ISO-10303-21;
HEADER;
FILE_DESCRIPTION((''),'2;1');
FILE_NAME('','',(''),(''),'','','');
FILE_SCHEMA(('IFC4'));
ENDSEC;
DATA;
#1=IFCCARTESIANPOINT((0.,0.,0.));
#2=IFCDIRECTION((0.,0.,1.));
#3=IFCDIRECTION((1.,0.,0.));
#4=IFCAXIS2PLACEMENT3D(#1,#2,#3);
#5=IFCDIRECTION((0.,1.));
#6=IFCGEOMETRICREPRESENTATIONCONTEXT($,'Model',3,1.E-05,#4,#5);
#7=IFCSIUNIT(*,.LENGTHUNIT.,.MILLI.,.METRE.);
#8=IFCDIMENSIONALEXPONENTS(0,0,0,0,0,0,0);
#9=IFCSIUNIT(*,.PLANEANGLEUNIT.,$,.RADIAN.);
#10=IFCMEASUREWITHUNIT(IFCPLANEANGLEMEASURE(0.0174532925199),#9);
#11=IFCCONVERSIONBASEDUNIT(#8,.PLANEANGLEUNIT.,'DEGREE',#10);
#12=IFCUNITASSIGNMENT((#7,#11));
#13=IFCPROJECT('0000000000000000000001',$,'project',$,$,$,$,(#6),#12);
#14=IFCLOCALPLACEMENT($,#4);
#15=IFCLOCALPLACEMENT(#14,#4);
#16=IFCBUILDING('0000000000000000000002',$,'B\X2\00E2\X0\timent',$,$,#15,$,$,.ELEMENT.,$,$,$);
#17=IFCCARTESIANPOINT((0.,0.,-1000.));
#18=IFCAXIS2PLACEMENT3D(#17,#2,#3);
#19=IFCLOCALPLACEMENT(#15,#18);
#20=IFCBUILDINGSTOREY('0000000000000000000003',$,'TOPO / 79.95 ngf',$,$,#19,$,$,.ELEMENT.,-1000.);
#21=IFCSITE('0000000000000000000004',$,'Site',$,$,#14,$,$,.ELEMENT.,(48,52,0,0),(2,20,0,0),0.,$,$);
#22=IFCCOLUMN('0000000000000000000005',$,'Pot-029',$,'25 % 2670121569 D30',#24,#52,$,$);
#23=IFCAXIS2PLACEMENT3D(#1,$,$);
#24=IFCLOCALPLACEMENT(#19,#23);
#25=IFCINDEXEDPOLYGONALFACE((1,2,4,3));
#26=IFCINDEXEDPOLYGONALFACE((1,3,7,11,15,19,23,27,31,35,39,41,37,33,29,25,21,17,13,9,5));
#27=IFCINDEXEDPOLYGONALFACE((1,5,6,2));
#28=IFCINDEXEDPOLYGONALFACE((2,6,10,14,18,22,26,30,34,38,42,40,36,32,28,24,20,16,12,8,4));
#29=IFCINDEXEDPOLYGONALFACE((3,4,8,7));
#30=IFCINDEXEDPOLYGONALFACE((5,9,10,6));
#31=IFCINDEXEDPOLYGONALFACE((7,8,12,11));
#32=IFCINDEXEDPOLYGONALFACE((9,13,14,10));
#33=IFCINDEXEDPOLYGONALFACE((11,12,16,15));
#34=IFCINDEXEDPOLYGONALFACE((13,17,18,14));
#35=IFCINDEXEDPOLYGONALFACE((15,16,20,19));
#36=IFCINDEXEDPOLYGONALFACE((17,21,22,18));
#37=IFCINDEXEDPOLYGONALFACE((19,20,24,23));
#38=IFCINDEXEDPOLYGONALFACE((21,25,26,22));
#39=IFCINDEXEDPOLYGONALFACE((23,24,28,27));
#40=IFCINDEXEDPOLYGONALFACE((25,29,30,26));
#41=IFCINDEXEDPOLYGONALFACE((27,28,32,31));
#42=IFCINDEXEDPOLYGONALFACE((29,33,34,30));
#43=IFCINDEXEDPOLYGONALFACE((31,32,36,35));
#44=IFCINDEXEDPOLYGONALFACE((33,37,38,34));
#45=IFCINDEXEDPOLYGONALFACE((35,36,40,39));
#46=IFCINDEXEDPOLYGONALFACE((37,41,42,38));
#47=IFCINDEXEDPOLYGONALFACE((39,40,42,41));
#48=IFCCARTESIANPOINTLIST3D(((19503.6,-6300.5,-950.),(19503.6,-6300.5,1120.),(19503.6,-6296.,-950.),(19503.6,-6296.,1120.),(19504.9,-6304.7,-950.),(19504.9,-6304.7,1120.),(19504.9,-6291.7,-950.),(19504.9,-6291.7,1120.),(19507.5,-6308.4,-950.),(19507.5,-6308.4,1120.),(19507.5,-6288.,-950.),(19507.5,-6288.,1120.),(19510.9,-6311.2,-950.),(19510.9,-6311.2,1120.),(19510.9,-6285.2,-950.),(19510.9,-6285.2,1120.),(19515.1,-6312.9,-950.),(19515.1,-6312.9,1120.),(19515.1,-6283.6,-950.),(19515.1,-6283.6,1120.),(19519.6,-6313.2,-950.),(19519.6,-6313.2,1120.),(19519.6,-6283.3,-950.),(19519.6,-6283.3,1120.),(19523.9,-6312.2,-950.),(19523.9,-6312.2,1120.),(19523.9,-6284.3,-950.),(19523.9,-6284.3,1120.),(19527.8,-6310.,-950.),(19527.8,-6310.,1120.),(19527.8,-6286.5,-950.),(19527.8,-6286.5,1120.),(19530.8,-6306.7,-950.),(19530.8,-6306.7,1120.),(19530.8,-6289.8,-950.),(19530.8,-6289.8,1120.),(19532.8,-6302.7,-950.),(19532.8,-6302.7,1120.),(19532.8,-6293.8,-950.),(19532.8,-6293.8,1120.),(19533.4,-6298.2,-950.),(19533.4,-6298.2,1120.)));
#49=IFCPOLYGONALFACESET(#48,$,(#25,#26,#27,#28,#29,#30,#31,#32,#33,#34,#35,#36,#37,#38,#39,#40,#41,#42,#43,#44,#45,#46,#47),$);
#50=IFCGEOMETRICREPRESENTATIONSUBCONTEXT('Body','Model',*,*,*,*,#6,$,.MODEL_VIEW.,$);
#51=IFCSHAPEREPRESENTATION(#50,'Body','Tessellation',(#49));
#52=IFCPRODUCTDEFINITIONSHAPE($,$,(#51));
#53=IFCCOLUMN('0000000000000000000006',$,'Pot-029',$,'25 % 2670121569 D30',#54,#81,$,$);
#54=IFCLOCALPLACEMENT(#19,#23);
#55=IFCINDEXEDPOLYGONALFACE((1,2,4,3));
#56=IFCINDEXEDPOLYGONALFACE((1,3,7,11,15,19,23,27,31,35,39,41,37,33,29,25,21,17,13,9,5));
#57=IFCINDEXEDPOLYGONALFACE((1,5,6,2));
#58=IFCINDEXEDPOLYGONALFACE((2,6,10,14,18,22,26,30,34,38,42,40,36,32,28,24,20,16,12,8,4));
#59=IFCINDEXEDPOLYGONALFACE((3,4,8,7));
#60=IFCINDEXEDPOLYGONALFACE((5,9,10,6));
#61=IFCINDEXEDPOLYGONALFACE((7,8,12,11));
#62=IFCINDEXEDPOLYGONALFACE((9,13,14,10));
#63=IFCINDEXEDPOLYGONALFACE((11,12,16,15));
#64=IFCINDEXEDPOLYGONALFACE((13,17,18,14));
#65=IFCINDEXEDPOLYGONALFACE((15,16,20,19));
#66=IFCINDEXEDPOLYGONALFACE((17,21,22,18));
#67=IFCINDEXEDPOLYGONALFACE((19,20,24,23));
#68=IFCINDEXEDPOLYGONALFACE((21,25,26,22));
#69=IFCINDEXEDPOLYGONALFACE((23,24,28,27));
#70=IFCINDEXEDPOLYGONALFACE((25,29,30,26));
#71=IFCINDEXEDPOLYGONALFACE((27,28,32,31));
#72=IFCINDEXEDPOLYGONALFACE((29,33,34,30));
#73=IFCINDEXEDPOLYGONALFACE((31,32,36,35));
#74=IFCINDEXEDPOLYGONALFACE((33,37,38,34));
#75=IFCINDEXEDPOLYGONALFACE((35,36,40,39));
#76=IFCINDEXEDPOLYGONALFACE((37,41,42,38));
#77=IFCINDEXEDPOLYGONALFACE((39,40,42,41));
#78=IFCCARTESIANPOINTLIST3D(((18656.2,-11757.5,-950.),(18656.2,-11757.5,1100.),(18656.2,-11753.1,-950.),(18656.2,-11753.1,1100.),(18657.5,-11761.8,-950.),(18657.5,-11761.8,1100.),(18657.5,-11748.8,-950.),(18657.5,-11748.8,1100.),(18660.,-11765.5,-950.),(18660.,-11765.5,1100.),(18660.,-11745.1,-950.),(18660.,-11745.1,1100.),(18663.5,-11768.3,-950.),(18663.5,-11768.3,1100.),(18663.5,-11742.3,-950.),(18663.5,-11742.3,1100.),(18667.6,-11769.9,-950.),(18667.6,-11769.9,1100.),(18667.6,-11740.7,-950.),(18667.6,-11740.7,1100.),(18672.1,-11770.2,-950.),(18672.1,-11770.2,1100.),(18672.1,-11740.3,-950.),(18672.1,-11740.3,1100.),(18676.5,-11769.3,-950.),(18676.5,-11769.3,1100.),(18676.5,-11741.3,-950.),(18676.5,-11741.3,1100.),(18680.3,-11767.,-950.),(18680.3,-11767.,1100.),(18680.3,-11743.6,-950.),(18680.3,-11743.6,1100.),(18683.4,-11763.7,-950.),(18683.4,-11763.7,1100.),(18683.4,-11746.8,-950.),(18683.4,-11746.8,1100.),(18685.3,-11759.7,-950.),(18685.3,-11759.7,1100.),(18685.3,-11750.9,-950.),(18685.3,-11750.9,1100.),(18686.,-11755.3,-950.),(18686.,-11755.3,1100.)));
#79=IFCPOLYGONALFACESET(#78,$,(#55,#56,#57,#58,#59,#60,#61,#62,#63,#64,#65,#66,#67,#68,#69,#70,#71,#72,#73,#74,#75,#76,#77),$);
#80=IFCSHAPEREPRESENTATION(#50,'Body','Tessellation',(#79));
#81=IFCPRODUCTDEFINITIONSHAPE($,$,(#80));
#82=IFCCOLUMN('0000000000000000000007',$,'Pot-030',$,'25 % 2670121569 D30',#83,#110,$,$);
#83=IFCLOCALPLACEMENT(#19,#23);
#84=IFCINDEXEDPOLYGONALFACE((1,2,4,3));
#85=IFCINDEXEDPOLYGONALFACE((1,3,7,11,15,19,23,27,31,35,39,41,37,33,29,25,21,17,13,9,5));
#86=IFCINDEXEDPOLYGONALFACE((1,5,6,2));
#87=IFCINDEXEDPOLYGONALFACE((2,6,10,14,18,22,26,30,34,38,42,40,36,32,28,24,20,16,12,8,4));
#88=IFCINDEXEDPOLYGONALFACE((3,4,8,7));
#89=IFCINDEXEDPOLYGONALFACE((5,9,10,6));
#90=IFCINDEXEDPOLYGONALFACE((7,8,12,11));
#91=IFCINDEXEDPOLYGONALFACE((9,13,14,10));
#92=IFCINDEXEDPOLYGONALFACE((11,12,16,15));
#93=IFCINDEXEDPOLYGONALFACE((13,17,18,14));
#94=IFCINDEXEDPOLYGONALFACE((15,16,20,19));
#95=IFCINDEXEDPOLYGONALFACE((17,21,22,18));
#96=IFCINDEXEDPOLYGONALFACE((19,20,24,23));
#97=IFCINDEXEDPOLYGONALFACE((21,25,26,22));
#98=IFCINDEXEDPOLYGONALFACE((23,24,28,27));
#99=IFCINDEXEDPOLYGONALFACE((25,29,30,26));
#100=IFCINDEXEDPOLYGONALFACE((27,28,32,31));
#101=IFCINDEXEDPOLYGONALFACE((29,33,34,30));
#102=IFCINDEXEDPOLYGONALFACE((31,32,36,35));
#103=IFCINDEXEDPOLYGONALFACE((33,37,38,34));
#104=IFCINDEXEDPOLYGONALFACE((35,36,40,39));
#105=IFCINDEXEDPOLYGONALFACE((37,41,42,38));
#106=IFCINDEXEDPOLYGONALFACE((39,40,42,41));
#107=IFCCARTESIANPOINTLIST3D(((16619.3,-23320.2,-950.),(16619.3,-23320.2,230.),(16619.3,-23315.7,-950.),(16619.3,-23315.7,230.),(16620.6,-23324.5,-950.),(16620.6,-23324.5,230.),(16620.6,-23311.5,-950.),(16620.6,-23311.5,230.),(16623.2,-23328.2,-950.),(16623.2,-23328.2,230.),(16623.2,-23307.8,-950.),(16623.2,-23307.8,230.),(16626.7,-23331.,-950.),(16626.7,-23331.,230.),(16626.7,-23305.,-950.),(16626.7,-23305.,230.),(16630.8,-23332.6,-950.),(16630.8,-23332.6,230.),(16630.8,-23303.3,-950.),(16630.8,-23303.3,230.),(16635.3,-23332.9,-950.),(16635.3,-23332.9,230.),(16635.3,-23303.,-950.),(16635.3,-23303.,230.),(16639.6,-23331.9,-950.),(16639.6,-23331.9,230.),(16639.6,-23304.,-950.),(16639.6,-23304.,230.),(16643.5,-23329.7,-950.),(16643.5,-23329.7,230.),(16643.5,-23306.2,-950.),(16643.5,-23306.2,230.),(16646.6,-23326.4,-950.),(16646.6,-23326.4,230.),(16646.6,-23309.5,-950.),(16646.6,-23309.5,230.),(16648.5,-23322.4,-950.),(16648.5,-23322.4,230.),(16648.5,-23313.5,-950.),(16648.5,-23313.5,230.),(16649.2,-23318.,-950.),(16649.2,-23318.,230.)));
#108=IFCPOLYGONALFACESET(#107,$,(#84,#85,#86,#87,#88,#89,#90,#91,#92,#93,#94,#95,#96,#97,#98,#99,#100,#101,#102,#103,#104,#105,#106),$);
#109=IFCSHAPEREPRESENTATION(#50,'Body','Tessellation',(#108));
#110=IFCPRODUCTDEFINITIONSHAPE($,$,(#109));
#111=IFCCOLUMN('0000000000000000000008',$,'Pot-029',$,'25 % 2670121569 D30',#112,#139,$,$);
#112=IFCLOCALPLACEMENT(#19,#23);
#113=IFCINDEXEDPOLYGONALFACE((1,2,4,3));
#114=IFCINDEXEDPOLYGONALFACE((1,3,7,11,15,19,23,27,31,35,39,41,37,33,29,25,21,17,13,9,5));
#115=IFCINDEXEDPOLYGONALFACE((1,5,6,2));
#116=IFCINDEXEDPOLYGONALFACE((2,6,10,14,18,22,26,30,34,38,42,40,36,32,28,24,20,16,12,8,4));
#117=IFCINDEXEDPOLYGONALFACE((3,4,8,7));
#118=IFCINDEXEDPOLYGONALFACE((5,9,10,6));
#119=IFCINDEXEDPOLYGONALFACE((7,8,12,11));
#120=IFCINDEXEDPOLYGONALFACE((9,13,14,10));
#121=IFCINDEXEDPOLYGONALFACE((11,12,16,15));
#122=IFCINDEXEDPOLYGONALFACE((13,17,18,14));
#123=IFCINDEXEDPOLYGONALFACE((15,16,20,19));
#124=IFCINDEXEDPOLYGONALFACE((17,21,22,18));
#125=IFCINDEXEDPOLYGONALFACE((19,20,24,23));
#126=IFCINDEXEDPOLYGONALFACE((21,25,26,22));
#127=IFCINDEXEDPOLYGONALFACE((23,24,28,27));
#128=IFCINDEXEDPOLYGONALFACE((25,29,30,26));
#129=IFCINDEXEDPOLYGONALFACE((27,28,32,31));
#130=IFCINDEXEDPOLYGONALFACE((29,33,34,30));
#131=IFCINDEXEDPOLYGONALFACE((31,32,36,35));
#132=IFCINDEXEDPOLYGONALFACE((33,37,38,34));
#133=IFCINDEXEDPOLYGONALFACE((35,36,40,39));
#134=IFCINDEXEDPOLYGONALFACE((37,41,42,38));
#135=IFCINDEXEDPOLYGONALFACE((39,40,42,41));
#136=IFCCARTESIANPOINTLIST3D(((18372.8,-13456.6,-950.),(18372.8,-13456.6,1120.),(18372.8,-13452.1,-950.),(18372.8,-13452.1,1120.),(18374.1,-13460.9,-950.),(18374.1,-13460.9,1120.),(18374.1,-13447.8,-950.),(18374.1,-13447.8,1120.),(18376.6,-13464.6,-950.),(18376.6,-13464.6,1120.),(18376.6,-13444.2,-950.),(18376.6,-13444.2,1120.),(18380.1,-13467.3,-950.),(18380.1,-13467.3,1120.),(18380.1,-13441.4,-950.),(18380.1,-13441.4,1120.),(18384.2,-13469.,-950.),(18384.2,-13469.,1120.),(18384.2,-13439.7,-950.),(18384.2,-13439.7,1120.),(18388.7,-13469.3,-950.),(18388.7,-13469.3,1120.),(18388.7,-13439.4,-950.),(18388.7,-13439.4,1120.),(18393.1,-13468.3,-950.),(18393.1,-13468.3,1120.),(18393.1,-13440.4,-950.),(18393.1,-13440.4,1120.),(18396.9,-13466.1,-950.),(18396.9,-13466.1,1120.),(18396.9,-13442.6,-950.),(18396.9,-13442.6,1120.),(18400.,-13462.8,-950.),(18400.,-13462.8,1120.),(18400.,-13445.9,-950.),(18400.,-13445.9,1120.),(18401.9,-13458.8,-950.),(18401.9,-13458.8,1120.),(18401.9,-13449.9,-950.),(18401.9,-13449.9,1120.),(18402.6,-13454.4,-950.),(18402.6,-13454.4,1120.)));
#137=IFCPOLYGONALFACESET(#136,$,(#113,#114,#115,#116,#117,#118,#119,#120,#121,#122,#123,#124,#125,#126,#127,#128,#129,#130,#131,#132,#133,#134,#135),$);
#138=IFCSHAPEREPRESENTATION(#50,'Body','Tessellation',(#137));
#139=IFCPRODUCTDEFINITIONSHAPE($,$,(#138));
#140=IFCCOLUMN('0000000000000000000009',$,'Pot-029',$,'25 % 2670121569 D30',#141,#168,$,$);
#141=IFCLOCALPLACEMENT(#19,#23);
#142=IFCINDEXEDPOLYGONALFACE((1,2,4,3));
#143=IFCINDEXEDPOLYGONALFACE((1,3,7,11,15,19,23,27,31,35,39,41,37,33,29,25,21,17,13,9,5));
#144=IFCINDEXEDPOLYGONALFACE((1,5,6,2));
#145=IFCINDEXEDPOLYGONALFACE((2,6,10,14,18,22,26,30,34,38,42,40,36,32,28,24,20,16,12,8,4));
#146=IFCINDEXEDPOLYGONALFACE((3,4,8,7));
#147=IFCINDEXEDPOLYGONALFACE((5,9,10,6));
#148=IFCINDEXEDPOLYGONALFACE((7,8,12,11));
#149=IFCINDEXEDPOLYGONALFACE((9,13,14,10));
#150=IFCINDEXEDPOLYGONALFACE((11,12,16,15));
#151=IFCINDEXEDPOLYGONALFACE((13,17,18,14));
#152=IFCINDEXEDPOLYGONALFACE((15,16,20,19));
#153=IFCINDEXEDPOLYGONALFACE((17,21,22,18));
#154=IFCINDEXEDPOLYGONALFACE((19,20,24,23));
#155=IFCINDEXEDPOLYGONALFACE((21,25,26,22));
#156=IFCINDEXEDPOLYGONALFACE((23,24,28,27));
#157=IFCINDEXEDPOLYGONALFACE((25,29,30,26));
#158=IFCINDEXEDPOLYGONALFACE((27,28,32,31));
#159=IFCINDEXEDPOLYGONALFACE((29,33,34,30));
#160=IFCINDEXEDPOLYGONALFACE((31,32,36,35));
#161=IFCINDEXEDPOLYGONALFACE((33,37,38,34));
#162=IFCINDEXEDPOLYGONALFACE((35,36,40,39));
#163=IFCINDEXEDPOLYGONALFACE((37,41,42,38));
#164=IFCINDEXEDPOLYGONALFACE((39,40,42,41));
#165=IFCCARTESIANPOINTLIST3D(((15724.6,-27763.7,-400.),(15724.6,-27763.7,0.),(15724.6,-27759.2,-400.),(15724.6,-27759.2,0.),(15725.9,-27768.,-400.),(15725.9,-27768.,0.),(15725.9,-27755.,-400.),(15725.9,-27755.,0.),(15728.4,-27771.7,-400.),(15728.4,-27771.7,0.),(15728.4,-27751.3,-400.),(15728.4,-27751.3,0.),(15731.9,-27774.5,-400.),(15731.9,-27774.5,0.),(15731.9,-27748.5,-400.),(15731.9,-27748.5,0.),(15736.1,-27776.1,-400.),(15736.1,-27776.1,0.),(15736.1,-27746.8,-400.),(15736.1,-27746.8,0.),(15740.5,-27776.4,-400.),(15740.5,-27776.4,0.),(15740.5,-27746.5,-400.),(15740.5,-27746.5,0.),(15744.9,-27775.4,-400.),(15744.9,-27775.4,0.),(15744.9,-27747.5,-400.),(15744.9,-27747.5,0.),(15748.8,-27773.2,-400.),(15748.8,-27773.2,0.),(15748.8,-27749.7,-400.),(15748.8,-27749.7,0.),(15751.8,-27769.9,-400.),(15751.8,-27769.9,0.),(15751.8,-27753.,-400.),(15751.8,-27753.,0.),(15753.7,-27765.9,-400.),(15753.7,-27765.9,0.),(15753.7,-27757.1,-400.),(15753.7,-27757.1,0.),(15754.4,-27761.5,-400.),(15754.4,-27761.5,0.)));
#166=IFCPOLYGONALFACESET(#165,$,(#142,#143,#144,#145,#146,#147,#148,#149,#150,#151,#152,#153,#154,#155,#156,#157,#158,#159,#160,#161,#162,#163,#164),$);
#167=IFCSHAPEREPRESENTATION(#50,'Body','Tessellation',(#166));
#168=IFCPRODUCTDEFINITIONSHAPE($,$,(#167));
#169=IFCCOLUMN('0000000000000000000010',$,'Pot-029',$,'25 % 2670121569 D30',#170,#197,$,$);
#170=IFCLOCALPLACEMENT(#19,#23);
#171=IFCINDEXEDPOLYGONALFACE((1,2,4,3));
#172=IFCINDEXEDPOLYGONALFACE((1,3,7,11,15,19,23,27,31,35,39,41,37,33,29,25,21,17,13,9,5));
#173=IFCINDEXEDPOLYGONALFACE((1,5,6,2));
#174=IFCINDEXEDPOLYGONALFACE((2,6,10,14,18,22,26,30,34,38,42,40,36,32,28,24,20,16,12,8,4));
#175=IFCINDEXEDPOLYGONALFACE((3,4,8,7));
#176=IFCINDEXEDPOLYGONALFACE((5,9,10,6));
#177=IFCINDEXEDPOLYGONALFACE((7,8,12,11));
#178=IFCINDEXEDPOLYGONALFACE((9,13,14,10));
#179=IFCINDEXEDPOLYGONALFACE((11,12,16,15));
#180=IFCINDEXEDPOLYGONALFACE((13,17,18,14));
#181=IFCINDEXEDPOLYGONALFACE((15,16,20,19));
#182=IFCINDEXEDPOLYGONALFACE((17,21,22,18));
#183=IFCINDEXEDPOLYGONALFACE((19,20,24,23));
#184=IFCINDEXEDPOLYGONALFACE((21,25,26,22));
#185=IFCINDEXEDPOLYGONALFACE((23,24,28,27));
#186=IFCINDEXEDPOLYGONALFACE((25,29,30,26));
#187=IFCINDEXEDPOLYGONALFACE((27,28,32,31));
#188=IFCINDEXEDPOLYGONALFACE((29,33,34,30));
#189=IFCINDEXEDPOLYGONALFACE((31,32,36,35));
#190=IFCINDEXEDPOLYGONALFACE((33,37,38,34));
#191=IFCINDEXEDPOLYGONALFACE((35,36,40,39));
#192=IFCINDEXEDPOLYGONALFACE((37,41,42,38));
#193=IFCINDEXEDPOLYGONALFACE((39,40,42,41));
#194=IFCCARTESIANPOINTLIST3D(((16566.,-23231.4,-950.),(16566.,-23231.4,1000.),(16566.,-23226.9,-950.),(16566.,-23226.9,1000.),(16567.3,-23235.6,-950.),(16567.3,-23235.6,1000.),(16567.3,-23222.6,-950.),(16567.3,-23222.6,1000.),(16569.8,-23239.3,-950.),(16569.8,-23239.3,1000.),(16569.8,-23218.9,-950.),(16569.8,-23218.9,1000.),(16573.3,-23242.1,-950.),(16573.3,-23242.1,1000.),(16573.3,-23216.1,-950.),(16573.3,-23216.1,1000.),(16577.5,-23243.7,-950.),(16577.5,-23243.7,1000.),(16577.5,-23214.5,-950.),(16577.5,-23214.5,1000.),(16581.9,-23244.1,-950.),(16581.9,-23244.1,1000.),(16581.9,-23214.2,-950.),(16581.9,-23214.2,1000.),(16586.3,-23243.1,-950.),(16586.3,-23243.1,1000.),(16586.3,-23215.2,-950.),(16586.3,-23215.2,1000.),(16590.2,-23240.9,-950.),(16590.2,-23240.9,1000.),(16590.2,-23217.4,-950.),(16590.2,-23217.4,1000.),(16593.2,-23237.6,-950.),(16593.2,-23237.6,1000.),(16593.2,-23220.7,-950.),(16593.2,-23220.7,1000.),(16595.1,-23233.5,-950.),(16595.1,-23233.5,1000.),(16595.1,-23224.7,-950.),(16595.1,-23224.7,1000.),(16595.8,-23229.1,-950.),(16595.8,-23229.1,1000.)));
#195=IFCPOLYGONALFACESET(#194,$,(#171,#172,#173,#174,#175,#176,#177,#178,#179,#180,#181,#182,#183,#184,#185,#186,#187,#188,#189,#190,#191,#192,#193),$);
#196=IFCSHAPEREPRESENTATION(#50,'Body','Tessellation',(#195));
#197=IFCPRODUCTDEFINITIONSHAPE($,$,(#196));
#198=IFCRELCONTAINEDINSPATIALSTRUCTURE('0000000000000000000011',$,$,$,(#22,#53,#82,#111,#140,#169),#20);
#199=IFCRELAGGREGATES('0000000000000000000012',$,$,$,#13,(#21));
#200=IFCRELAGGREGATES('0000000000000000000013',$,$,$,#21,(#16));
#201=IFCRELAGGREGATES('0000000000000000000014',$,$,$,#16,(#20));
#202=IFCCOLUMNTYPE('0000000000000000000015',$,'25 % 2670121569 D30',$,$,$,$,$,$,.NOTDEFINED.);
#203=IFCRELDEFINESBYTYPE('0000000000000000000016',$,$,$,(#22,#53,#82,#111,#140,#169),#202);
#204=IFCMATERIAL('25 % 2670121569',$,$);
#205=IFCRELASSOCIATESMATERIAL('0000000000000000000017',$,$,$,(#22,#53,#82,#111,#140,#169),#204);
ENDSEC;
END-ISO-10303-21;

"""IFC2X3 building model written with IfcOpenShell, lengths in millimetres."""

from ifc_helpers import new_model, entity, si_unit, converted_unit, direction, frame, origin_with_axes, origin_2d_with_axis, place, context, subcontext, project, spatial, circle, extrude, material, type_object, element, save


model = new_model("IFC2X3")

# Units and contexts
model_context = context("Model", 3, precision=1e-05, world=origin_with_axes(), true_north=direction((0.0, 1.0)))
body_context = subcontext(model_context, "Body", "Model", "MODEL_VIEW")
ifc_project = project(units=[si_unit("LENGTHUNIT", "METRE", prefix="MILLI"), converted_unit("PLANEANGLEUNIT", "DEGREE", entity("IfcPlaneAngleMeasure", 0.0174532925199), si_unit("PLANEANGLEUNIT", "RADIAN"), dimensions=[0, 0, 0, 0, 0, 0, 0])], contexts=[model_context])

# Site, building, storey
site_placement = place(None, origin_with_axes())
site = spatial("IfcSite", under=ifc_project, at=site_placement, Name="Site", CompositionType="ELEMENT", RefLatitude=(48, 52, 0, 0), RefLongitude=(2, 20, 0, 0), RefElevation=0.0)
building_placement = place(site_placement, origin_with_axes())
building = spatial("IfcBuilding", under=site, at=building_placement, Name="Bâtiment", CompositionType="ELEMENT")
storey_placement = place(building_placement, frame((0.0, 0.0, -1000.0), z_axis=(0.0, 0.0, 1.0), x_axis=(1.0, 0.0, 0.0)))
storey = spatial("IfcBuildingStorey", under=building, at=storey_placement, Name="TOPO / 79.95 ngf", CompositionType="ELEMENT", Elevation=-1000.0)

# Columns
ifc_material_1 = material(Name="25 % 2670121569")
column_type = type_object("IfcColumnType", Name="25 % 2670121569 D30", PredefinedType="NOTDEFINED")
column_1_placement = place(storey_placement, frame((19518.4, -6298.2, -950.0), z_axis=(0.0, 0.0, 1.0), x_axis=(1.0, 0.0, 0.0)))
element("IfcColumn", 1, at=column_1_placement, inside=storey, type_object=column_type, material=ifc_material_1, Name="Pot-029", ObjectType="25 % 2670121569 D30", context=body_context, shape_type="SweptSolid", body=[
    extrude(circle(Radius=15.0, at=origin_2d_with_axis()), origin_with_axes(), (0.0, 0.0, 1.0), 2070.0),
])
column_2_placement = place(storey_placement, frame((18671.0, -11755.3, -950.0), z_axis=(0.0, 0.0, 1.0), x_axis=(1.0, 0.0, 0.0)))
element("IfcColumn", 2, at=column_2_placement, inside=storey, type_object=column_type, material=ifc_material_1, Name="Pot-029", ObjectType="25 % 2670121569 D30", context=body_context, shape_type="SweptSolid", body=[
    extrude(circle(Radius=15.0, at=origin_2d_with_axis()), origin_with_axes(), (0.0, 0.0, 1.0), 2050.0),
])
column_3_placement = place(storey_placement, frame((16634.2, -23318.0, -950.0), z_axis=(0.0, 0.0, 1.0), x_axis=(1.0, 0.0, 0.0)))
element("IfcColumn", 3, at=column_3_placement, inside=storey, type_object=column_type, material=ifc_material_1, Name="Pot-030", ObjectType="25 % 2670121569 D30", context=body_context, shape_type="SweptSolid", body=[
    extrude(circle(Radius=15.0, at=origin_2d_with_axis()), origin_with_axes(), (0.0, 0.0, 1.0), 1180.0),
])
column_4_placement = place(storey_placement, frame((18387.6, -13454.4, -950.0), z_axis=(0.0, 0.0, 1.0), x_axis=(1.0, 0.0, 0.0)))
element("IfcColumn", 4, at=column_4_placement, inside=storey, type_object=column_type, material=ifc_material_1, Name="Pot-029", ObjectType="25 % 2670121569 D30", context=body_context, shape_type="SweptSolid", body=[
    extrude(circle(Radius=15.0, at=origin_2d_with_axis()), origin_with_axes(), (0.0, 0.0, 1.0), 2070.0),
])
column_5_placement = place(storey_placement, frame((15739.4, -27761.5, -400.0), z_axis=(0.0, 0.0, 1.0), x_axis=(1.0, 0.0, 0.0)))
element("IfcColumn", 5, at=column_5_placement, inside=storey, type_object=column_type, material=ifc_material_1, Name="Pot-029", ObjectType="25 % 2670121569 D30", context=body_context, shape_type="SweptSolid", body=[
    extrude(circle(Radius=15.0, at=origin_2d_with_axis()), origin_with_axes(), (0.0, 0.0, 1.0), 400.0),
])
column_6_placement = place(storey_placement, frame((16580.8, -23229.1, -950.0), z_axis=(0.0, 0.0, 1.0), x_axis=(1.0, 0.0, 0.0)))
element("IfcColumn", 6, at=column_6_placement, inside=storey, type_object=column_type, material=ifc_material_1, Name="Pot-029", ObjectType="25 % 2670121569 D30", context=body_context, shape_type="SweptSolid", body=[
    extrude(circle(Radius=15.0, at=origin_2d_with_axis()), origin_with_axes(), (0.0, 0.0, 1.0), 1950.0),
])

save(model, "model.ifc")
